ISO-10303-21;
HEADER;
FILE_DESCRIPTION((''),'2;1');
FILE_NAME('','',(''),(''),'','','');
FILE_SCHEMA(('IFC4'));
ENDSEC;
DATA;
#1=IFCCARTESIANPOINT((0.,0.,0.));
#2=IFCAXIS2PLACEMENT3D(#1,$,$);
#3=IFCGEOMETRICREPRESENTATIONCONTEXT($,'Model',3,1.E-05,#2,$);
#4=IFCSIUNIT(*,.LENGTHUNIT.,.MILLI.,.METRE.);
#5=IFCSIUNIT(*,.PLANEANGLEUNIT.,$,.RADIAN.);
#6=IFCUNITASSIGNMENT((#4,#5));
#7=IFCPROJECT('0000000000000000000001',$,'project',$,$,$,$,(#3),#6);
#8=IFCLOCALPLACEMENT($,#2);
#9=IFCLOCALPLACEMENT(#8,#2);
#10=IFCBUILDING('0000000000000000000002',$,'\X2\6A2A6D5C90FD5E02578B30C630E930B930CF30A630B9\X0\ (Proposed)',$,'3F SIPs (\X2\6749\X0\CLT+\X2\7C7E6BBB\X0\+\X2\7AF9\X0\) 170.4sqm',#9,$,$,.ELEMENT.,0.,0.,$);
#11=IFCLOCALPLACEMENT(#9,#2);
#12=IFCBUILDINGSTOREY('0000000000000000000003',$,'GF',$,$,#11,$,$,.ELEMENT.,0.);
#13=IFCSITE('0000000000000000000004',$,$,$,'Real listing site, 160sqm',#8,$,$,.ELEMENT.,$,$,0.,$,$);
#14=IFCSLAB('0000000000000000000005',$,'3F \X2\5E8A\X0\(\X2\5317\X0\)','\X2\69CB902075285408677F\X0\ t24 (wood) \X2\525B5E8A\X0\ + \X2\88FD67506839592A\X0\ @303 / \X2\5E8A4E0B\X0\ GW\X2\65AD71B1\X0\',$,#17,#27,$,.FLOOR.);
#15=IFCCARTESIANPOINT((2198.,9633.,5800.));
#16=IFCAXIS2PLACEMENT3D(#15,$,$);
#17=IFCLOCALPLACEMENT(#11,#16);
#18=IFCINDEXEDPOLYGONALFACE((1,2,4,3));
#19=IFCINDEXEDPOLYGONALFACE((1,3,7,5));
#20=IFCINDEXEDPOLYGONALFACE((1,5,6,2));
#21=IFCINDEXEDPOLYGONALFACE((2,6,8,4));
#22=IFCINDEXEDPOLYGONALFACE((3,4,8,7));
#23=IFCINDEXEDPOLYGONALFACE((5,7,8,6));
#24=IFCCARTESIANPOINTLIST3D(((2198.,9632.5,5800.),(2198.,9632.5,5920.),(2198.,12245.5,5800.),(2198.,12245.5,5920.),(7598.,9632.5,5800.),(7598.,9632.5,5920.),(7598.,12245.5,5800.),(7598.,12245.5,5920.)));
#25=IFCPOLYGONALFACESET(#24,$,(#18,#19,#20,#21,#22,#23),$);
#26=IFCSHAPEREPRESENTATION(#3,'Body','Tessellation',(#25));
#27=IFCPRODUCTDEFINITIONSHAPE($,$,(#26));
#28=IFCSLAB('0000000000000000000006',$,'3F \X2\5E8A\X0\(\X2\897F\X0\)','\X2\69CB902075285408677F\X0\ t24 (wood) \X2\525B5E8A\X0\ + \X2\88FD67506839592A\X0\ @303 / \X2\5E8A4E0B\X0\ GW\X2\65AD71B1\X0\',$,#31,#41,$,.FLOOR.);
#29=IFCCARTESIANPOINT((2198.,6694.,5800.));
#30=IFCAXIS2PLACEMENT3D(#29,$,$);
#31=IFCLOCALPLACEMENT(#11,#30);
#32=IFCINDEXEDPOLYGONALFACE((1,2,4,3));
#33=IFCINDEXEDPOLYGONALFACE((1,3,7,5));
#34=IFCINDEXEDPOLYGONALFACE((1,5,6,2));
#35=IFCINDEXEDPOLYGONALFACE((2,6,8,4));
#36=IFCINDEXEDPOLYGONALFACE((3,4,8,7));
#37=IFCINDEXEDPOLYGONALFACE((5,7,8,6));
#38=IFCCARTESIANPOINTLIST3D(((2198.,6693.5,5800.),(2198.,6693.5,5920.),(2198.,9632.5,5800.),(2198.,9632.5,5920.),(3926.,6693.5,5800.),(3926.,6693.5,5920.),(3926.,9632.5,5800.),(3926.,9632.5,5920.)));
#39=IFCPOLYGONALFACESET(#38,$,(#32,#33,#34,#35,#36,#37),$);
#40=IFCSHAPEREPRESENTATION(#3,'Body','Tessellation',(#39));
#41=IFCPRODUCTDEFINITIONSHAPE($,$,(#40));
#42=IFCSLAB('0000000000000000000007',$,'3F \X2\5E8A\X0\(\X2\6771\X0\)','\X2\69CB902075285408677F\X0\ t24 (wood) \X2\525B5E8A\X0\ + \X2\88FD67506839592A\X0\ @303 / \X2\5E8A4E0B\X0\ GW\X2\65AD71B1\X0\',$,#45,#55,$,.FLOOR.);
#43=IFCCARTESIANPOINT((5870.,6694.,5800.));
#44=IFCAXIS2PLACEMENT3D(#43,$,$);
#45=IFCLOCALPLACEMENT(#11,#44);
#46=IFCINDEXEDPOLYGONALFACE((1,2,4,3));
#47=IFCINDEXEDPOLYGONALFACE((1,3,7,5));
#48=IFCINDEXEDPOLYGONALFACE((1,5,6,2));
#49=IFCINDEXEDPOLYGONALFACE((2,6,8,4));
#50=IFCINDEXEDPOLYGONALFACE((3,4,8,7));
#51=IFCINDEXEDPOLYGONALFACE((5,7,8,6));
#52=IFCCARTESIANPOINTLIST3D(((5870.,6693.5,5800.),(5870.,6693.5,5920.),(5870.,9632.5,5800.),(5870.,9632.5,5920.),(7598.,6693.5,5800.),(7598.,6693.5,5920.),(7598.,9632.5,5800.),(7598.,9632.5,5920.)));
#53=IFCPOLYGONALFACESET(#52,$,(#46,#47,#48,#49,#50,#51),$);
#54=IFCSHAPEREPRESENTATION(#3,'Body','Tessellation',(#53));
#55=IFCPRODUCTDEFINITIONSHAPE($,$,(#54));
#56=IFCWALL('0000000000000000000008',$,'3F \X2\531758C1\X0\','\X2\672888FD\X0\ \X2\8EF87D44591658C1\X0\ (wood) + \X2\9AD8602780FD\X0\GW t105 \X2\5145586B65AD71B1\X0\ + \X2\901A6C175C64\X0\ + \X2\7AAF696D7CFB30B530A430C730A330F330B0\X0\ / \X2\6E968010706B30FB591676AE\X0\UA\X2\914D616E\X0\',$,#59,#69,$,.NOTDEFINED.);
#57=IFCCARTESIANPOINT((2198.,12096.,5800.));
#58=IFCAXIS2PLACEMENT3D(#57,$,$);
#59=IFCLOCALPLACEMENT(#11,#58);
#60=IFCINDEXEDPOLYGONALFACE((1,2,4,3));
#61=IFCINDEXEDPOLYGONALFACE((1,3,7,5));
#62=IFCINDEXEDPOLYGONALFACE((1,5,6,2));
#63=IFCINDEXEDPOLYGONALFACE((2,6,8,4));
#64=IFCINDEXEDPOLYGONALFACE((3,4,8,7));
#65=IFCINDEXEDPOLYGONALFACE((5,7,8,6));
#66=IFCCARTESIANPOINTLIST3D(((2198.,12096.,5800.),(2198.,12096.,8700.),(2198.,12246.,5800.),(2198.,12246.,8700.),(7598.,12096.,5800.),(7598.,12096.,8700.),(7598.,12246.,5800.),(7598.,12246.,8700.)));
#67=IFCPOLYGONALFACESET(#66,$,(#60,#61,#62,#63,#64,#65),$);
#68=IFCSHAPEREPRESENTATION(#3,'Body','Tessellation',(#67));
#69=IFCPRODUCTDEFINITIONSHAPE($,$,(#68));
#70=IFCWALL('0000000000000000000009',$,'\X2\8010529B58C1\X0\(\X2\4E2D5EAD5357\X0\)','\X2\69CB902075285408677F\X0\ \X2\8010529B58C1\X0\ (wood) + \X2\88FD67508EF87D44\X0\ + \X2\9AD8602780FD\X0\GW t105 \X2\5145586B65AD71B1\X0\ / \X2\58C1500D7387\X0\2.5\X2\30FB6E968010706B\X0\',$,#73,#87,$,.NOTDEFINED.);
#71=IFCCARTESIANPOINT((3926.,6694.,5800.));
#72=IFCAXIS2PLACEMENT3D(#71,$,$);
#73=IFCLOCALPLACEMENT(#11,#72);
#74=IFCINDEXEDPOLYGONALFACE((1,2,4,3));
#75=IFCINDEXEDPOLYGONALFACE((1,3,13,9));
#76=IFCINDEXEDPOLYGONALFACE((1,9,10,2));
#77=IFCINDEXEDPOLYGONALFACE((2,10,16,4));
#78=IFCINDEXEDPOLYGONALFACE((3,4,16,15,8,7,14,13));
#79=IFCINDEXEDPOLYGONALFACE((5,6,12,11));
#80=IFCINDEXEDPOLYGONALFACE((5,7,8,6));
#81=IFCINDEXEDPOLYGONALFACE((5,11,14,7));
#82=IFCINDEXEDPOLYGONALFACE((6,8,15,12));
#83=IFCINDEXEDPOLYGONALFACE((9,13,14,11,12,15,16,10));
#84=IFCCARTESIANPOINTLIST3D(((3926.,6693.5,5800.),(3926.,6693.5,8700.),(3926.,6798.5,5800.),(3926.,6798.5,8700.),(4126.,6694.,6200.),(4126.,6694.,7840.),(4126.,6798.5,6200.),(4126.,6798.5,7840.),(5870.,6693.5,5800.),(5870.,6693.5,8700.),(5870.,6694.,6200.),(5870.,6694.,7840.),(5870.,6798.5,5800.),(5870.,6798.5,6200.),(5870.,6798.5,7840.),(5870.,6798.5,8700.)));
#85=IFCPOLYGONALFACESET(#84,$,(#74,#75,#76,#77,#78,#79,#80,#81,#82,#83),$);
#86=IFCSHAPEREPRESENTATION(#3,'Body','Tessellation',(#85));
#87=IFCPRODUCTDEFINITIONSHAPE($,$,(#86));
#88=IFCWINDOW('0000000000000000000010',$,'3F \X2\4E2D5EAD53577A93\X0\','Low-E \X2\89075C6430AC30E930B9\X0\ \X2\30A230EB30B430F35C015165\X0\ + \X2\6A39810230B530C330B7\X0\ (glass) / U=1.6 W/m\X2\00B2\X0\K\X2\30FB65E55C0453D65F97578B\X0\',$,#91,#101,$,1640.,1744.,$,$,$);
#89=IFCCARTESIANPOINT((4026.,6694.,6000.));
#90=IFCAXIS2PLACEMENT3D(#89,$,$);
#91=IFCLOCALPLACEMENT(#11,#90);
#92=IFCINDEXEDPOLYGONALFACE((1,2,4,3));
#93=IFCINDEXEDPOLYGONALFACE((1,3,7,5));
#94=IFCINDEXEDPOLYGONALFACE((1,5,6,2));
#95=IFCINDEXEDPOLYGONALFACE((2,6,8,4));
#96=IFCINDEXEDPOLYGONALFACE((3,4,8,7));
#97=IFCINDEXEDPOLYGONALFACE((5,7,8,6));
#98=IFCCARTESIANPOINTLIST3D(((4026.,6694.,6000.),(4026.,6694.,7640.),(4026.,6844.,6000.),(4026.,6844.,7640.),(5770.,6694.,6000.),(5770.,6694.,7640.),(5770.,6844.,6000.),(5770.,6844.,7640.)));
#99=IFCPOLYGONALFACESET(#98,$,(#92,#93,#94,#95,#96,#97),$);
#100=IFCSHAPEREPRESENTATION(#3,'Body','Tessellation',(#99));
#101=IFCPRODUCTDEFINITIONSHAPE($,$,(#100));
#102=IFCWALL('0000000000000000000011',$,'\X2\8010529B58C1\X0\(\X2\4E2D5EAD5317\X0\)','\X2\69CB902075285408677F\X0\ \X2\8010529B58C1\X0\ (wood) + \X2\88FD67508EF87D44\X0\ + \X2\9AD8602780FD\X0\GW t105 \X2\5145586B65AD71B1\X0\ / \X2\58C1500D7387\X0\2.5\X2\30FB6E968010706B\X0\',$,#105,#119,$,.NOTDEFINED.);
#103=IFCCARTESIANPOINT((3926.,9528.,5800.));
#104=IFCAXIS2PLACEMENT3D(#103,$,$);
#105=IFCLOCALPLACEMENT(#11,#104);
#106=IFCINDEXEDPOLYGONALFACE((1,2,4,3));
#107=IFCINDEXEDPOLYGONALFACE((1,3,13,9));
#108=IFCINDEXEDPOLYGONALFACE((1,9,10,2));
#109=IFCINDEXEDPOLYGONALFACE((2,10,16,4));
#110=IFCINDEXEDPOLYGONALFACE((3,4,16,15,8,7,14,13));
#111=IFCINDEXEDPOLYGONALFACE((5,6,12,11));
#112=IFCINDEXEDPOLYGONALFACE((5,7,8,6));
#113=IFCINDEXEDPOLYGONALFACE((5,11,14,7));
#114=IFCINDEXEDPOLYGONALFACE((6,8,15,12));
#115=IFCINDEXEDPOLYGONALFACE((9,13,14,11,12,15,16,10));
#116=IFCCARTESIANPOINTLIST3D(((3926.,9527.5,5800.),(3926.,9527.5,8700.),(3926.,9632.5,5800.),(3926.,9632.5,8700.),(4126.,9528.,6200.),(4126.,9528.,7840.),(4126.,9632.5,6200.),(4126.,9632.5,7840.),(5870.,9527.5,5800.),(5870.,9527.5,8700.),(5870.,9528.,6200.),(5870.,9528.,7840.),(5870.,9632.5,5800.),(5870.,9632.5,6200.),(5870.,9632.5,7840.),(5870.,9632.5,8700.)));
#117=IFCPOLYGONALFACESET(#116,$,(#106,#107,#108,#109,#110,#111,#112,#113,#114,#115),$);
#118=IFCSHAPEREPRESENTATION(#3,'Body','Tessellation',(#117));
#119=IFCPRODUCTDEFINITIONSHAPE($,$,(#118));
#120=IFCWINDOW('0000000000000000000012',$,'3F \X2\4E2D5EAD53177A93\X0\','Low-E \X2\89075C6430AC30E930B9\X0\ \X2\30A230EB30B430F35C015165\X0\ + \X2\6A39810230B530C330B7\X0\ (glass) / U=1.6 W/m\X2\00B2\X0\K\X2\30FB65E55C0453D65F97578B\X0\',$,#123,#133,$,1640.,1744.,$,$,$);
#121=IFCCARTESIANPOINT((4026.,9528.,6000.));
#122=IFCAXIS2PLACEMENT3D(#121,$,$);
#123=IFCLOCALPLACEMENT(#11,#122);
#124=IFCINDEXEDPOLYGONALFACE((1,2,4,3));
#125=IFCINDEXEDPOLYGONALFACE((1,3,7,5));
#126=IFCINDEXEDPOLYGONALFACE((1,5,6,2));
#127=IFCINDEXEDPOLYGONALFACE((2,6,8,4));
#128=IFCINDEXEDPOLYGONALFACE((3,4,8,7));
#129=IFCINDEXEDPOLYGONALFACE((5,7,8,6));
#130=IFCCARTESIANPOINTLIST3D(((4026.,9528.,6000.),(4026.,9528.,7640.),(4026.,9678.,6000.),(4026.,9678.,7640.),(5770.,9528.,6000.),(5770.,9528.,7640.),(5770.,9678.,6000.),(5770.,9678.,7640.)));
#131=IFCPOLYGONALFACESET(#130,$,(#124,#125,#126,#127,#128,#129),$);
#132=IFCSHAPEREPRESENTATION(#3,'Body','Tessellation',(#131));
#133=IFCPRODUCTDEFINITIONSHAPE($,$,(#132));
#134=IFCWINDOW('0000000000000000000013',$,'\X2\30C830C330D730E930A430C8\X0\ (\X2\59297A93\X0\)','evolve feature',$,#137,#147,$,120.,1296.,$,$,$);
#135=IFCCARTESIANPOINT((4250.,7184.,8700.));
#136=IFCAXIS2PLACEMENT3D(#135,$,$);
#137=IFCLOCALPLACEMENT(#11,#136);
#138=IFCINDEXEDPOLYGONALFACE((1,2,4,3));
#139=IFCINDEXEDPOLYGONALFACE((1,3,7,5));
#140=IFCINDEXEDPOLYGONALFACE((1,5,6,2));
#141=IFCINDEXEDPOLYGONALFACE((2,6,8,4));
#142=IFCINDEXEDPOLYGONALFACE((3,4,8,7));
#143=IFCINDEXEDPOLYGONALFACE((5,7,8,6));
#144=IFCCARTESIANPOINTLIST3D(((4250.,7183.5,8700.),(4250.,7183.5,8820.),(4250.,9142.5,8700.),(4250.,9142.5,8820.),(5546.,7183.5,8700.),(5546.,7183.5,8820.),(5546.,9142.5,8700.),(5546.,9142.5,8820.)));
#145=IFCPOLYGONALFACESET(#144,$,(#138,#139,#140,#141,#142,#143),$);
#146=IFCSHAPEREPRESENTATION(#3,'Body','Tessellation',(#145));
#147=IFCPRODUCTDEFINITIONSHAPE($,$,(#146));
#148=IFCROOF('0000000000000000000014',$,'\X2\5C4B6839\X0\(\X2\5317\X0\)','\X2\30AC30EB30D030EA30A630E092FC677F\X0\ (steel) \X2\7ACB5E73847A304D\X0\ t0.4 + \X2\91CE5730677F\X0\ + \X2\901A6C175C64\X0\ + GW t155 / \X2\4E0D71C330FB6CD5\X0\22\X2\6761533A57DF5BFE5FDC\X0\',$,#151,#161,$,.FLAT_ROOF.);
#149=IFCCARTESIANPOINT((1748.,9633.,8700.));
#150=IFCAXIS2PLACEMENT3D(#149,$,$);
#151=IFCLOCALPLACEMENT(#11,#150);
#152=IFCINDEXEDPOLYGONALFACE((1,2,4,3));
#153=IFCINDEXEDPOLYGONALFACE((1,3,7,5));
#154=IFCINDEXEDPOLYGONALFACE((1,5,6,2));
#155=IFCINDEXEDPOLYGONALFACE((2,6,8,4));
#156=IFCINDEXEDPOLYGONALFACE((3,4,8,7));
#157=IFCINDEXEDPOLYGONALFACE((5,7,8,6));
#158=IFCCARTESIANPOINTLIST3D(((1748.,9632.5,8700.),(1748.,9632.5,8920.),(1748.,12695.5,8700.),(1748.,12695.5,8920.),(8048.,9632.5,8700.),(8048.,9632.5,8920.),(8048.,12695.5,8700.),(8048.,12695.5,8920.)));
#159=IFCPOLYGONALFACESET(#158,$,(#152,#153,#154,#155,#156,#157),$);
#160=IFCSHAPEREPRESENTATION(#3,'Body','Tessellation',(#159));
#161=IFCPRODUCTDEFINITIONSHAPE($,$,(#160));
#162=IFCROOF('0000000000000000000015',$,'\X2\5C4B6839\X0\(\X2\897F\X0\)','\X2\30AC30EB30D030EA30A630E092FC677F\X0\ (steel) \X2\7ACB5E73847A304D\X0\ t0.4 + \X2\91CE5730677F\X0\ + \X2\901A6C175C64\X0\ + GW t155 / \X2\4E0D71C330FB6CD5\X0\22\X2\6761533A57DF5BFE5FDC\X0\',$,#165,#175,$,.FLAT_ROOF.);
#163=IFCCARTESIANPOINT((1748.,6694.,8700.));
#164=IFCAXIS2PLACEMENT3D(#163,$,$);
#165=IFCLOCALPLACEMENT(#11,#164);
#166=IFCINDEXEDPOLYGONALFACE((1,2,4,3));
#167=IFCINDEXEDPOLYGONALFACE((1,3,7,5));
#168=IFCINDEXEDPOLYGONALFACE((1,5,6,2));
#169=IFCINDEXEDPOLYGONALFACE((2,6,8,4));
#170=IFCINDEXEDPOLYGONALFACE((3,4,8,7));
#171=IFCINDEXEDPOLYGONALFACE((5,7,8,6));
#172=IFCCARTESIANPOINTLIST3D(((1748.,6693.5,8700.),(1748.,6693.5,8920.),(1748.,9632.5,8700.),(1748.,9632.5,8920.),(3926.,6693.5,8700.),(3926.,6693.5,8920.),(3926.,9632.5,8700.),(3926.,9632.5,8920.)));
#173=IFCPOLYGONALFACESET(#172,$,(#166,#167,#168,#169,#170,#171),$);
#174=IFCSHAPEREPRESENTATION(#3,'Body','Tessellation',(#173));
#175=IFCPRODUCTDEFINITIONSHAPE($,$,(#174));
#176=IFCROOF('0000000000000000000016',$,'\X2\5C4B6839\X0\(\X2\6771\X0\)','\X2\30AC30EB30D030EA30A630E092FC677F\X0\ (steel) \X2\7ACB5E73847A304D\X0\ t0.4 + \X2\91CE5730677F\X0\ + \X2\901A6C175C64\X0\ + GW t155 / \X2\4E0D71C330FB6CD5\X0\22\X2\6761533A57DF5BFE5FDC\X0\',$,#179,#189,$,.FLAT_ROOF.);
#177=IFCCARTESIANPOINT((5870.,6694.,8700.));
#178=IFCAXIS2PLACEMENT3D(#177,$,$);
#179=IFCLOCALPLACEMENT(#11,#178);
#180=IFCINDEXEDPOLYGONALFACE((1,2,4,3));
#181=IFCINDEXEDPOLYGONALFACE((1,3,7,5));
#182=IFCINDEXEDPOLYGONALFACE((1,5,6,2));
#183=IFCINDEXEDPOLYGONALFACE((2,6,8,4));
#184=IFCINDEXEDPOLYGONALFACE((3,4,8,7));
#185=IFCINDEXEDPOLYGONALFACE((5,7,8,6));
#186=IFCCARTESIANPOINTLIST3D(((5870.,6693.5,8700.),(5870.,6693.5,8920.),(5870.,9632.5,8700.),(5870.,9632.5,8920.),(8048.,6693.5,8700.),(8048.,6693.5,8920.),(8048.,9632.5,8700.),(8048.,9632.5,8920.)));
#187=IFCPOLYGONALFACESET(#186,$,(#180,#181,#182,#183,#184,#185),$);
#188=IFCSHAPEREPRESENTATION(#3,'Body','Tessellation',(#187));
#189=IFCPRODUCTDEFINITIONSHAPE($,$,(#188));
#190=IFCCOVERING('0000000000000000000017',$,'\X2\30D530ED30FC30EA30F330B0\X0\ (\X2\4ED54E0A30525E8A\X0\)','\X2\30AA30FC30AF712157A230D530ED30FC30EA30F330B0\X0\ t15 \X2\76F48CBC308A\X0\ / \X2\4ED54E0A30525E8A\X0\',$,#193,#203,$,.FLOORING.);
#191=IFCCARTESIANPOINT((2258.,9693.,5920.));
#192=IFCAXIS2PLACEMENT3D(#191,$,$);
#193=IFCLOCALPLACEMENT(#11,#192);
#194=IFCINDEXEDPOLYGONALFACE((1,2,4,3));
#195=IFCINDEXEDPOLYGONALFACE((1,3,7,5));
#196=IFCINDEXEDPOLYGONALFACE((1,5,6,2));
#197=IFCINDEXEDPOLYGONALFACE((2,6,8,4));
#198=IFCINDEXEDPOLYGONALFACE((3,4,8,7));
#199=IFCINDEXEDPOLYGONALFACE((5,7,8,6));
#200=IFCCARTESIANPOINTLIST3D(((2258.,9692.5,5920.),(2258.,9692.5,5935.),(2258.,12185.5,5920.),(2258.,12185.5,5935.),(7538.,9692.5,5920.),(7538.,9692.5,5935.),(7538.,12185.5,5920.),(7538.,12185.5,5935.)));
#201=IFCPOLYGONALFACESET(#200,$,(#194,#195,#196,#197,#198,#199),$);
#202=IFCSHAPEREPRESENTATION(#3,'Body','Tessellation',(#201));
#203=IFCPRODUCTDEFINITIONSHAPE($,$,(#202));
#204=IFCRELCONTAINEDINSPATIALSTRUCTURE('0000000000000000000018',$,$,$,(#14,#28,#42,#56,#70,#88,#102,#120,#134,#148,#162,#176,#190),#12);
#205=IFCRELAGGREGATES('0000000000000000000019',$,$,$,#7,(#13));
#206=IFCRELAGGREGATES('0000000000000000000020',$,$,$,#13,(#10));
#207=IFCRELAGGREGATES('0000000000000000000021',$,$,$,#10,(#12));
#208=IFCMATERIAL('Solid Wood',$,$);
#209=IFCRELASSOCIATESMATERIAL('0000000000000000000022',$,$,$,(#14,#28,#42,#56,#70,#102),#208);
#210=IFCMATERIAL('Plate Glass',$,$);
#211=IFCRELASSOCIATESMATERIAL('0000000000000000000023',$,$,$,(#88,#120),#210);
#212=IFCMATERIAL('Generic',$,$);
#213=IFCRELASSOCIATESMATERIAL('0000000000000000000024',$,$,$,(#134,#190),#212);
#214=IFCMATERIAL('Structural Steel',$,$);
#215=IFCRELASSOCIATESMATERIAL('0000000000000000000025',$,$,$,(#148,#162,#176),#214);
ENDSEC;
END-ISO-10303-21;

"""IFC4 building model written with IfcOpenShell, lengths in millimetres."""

from ifc_helpers import new_model, si_unit, frame, frame_2d, origin, place, context, project, spatial, rectangle, extrude, material, element, fill, save


model = new_model("IFC4")

# Units and contexts
model_context = context("Model", 3, precision=1e-05, world=origin())
ifc_project = project(units=[si_unit("LENGTHUNIT", "METRE", prefix="MILLI"), si_unit("PLANEANGLEUNIT", "RADIAN")], contexts=[model_context])

# Site, building, storey
site_placement = place(None, origin())
site = spatial("IfcSite", under=ifc_project, at=site_placement, ObjectType="Real listing site, 160sqm", CompositionType="ELEMENT", RefElevation=0.0)
building_placement = place(site_placement, origin())
building = spatial("IfcBuilding", under=site, at=building_placement, Name="横浜都市型テラスハウス (Proposed)", ObjectType="3F SIPs (杉CLT+籾殻+竹) 170.4sqm", CompositionType="ELEMENT", ElevationOfRefHeight=0.0, ElevationOfTerrain=0.0)
storey_placement = place(building_placement, origin())
storey = spatial("IfcBuildingStorey", under=building, at=storey_placement, Name="GF", CompositionType="ELEMENT", Elevation=0.0)

# Slabs
ifc_material_1 = material(Name="Solid Wood")
slab_1_placement = place(storey_placement, frame((2198.0, 9633.0, 5800.0)))
element("IfcSlab", 1, at=slab_1_placement, inside=storey, material=ifc_material_1, Name="3F 床(北)", Description="構造用合板 t24 (wood) 剛床 + 製材根太 @303 / 床下 GW断熱", PredefinedType="FLOOR", context=model_context, shape_type="SweptSolid", body=[
    extrude(rectangle(XDim=5400.0, YDim=2613.0, at=frame_2d((2700.0, 1306.0))), frame((2198.0, 9633.0, 5800.0)), (0.0, 0.0, 1.0), 120.0),
])
slab_2_placement = place(storey_placement, frame((2198.0, 6694.0, 5800.0)))
element("IfcSlab", 2, at=slab_2_placement, inside=storey, material=ifc_material_1, Name="3F 床(西)", Description="構造用合板 t24 (wood) 剛床 + 製材根太 @303 / 床下 GW断熱", PredefinedType="FLOOR", context=model_context, shape_type="SweptSolid", body=[
    extrude(rectangle(XDim=1728.0, YDim=2939.0, at=frame_2d((864.0, 1469.0))), frame((2198.0, 6694.0, 5800.0)), (0.0, 0.0, 1.0), 120.0),
])
slab_3_placement = place(storey_placement, frame((5870.0, 6694.0, 5800.0)))
element("IfcSlab", 3, at=slab_3_placement, inside=storey, material=ifc_material_1, Name="3F 床(東)", Description="構造用合板 t24 (wood) 剛床 + 製材根太 @303 / 床下 GW断熱", PredefinedType="FLOOR", context=model_context, shape_type="SweptSolid", body=[
    extrude(rectangle(XDim=1728.0, YDim=2939.0, at=frame_2d((864.0, 1469.0))), frame((5870.0, 6694.0, 5800.0)), (0.0, 0.0, 1.0), 120.0),
])

# Wall
wall_1_placement = place(storey_placement, frame((2198.0, 12096.0, 5800.0)))
element("IfcWall", 4, at=wall_1_placement, inside=storey, material=ifc_material_1, Name="3F 北壁", Description="木製 軸組外壁 (wood) + 高性能GW t105 充填断熱 + 通気層 + 窯業系サイディング / 準耐火・外皮UA配慮", PredefinedType="NOTDEFINED", context=model_context, shape_type="SweptSolid", body=[
    extrude(rectangle(XDim=5400.0, YDim=150.0, at=frame_2d((2700.0, 75.0))), frame((2198.0, 12096.0, 5800.0)), (0.0, 0.0, 1.0), 2900.0),
])

# Walls, openings, windows
wall_2_placement = place(storey_placement, frame((3926.0, 6694.0, 5800.0)))
wall_2 = element("IfcWall", 5, at=wall_2_placement, inside=storey, material=ifc_material_1, Name="耐力壁(中庭南)", Description="構造用合板 耐力壁 (wood) + 製材軸組 + 高性能GW t105 充填断熱 / 壁倍率2.5・準耐火", PredefinedType="NOTDEFINED", context=model_context, shape_type="SweptSolid", body=[
    extrude(rectangle(XDim=1944.0, YDim=105.0, at=frame_2d((972.0, 52.0))), frame((3926.0, 6694.0, 5800.0)), (0.0, 0.0, 1.0), 2900.0),
])
opening_1_placement = place(storey_placement, frame((4026.0, 6694.0, 6000.0)))
opening_1 = element("IfcOpeningElement", 6, at=opening_1_placement, cuts=wall_2, PredefinedType="NOTDEFINED", context=model_context, shape_type="SweptSolid", body=[
    extrude(rectangle(XDim=1744.0, YDim=150.0, at=frame_2d((872.0, 75.0))), frame((4026.0, 6694.0, 6000.0)), (0.0, 0.0, 1.0), 1640.0),
])
ifc_material_2 = material(Name="Plate Glass")
window_1_placement = place(storey_placement, frame((4026.0, 6694.0, 6000.0)))
window_1 = element("IfcWindow", 7, at=window_1_placement, inside=storey, material=ifc_material_2, Name="3F 中庭南窓", Description="Low-E 複層ガラス アルゴン封入 + 樹脂サッシ (glass) / U=1.6 W/m²K・日射取得型", OverallHeight=1640.0, OverallWidth=1744.0, context=model_context, shape_type="SweptSolid", body=[
    extrude(rectangle(XDim=1744.0, YDim=150.0, at=frame_2d((872.0, 75.0))), frame((4026.0, 6694.0, 6000.0)), (0.0, 0.0, 1.0), 1640.0),
])
fill(opening_1, window_1)
wall_3_placement = place(storey_placement, frame((3926.0, 9528.0, 5800.0)))
wall_3 = element("IfcWall", 8, at=wall_3_placement, inside=storey, material=ifc_material_1, Name="耐力壁(中庭北)", Description="構造用合板 耐力壁 (wood) + 製材軸組 + 高性能GW t105 充填断熱 / 壁倍率2.5・準耐火", PredefinedType="NOTDEFINED", context=model_context, shape_type="SweptSolid", body=[
    extrude(rectangle(XDim=1944.0, YDim=105.0, at=frame_2d((972.0, 52.0))), frame((3926.0, 9528.0, 5800.0)), (0.0, 0.0, 1.0), 2900.0),
])
opening_2_placement = place(storey_placement, frame((4026.0, 9528.0, 6000.0)))
opening_2 = element("IfcOpeningElement", 9, at=opening_2_placement, cuts=wall_3, PredefinedType="NOTDEFINED", context=model_context, shape_type="SweptSolid", body=[
    extrude(rectangle(XDim=1744.0, YDim=150.0, at=frame_2d((872.0, 75.0))), frame((4026.0, 9528.0, 6000.0)), (0.0, 0.0, 1.0), 1640.0),
])
window_2_placement = place(storey_placement, frame((4026.0, 9528.0, 6000.0)))
window_2 = element("IfcWindow", 10, at=window_2_placement, inside=storey, material=ifc_material_2, Name="3F 中庭北窓", Description="Low-E 複層ガラス アルゴン封入 + 樹脂サッシ (glass) / U=1.6 W/m²K・日射取得型", OverallHeight=1640.0, OverallWidth=1744.0, context=model_context, shape_type="SweptSolid", body=[
    extrude(rectangle(XDim=1744.0, YDim=150.0, at=frame_2d((872.0, 75.0))), frame((4026.0, 9528.0, 6000.0)), (0.0, 0.0, 1.0), 1640.0),
])
fill(opening_2, window_2)

# Window
ifc_material_3 = material(Name="Generic")
window_3_placement = place(storey_placement, frame((4250.0, 7184.0, 8700.0)))
element("IfcWindow", 11, at=window_3_placement, inside=storey, material=ifc_material_3, Name="トップライト (天窓)", Description="evolve feature", OverallHeight=120.0, OverallWidth=1296.0, context=model_context, shape_type="SweptSolid", body=[
    extrude(rectangle(XDim=1296.0, YDim=1959.0, at=frame_2d((648.0, 979.0))), frame((4250.0, 7184.0, 8700.0)), (0.0, 0.0, 1.0), 120.0),
])

# Roofs
ifc_material_4 = material(Name="Structural Steel")
for number, where, name in (
    (12, (1748.0, 9633.0, 8700.0), "屋根(北)"),
):
    element("IfcRoof", number, at=place(storey_placement, frame(where)), inside=storey, material=ifc_material_4, Name=name, Description="ガルバリウム鋼板 (steel) 立平葺き t0.4 + 野地板 + 通気層 + GW t155 / 不燃・法22条区域対応", PredefinedType="FLAT_ROOF", context=model_context, shape_type="SweptSolid", body=[
        extrude(rectangle(XDim=6300.0, YDim=3063.0, at=frame_2d((3150.0, 1531.0))), frame((1748.0, 9633.0, 8700.0)), (0.0, 0.0, 1.0), 220.0),
    ])
roof_1_placement = place(storey_placement, frame((1748.0, 6694.0, 8700.0)))
element("IfcRoof", 13, at=roof_1_placement, inside=storey, material=ifc_material_4, Name="屋根(西)", Description="ガルバリウム鋼板 (steel) 立平葺き t0.4 + 野地板 + 通気層 + GW t155 / 不燃・法22条区域対応", PredefinedType="FLAT_ROOF", context=model_context, shape_type="SweptSolid", body=[
    extrude(rectangle(XDim=2178.0, YDim=2939.0, at=frame_2d((1089.0, 1469.0))), frame((1748.0, 6694.0, 8700.0)), (0.0, 0.0, 1.0), 220.0),
])
roof_2_placement = place(storey_placement, frame((5870.0, 6694.0, 8700.0)))
element("IfcRoof", 14, at=roof_2_placement, inside=storey, material=ifc_material_4, Name="屋根(東)", Description="ガルバリウム鋼板 (steel) 立平葺き t0.4 + 野地板 + 通気層 + GW t155 / 不燃・法22条区域対応", PredefinedType="FLAT_ROOF", context=model_context, shape_type="SweptSolid", body=[
    extrude(rectangle(XDim=2178.0, YDim=2939.0, at=frame_2d((1089.0, 1469.0))), frame((5870.0, 6694.0, 8700.0)), (0.0, 0.0, 1.0), 220.0),
])

# Covering
covering_1_placement = place(storey_placement, frame((2258.0, 9693.0, 5920.0)))
element("IfcCovering", 15, at=covering_1_placement, inside=storey, material=ifc_material_3, Name="フローリング (仕上げ床)", Description="オーク無垢フローリング t15 直貼り / 仕上げ床", PredefinedType="FLOORING", context=model_context, shape_type="SweptSolid", body=[
    extrude(rectangle(XDim=5280.0, YDim=2493.0, at=frame_2d((2640.0, 1246.0))), frame((2258.0, 9693.0, 5920.0)), (0.0, 0.0, 1.0), 15.0),
])

save(model, "model.ifc")
